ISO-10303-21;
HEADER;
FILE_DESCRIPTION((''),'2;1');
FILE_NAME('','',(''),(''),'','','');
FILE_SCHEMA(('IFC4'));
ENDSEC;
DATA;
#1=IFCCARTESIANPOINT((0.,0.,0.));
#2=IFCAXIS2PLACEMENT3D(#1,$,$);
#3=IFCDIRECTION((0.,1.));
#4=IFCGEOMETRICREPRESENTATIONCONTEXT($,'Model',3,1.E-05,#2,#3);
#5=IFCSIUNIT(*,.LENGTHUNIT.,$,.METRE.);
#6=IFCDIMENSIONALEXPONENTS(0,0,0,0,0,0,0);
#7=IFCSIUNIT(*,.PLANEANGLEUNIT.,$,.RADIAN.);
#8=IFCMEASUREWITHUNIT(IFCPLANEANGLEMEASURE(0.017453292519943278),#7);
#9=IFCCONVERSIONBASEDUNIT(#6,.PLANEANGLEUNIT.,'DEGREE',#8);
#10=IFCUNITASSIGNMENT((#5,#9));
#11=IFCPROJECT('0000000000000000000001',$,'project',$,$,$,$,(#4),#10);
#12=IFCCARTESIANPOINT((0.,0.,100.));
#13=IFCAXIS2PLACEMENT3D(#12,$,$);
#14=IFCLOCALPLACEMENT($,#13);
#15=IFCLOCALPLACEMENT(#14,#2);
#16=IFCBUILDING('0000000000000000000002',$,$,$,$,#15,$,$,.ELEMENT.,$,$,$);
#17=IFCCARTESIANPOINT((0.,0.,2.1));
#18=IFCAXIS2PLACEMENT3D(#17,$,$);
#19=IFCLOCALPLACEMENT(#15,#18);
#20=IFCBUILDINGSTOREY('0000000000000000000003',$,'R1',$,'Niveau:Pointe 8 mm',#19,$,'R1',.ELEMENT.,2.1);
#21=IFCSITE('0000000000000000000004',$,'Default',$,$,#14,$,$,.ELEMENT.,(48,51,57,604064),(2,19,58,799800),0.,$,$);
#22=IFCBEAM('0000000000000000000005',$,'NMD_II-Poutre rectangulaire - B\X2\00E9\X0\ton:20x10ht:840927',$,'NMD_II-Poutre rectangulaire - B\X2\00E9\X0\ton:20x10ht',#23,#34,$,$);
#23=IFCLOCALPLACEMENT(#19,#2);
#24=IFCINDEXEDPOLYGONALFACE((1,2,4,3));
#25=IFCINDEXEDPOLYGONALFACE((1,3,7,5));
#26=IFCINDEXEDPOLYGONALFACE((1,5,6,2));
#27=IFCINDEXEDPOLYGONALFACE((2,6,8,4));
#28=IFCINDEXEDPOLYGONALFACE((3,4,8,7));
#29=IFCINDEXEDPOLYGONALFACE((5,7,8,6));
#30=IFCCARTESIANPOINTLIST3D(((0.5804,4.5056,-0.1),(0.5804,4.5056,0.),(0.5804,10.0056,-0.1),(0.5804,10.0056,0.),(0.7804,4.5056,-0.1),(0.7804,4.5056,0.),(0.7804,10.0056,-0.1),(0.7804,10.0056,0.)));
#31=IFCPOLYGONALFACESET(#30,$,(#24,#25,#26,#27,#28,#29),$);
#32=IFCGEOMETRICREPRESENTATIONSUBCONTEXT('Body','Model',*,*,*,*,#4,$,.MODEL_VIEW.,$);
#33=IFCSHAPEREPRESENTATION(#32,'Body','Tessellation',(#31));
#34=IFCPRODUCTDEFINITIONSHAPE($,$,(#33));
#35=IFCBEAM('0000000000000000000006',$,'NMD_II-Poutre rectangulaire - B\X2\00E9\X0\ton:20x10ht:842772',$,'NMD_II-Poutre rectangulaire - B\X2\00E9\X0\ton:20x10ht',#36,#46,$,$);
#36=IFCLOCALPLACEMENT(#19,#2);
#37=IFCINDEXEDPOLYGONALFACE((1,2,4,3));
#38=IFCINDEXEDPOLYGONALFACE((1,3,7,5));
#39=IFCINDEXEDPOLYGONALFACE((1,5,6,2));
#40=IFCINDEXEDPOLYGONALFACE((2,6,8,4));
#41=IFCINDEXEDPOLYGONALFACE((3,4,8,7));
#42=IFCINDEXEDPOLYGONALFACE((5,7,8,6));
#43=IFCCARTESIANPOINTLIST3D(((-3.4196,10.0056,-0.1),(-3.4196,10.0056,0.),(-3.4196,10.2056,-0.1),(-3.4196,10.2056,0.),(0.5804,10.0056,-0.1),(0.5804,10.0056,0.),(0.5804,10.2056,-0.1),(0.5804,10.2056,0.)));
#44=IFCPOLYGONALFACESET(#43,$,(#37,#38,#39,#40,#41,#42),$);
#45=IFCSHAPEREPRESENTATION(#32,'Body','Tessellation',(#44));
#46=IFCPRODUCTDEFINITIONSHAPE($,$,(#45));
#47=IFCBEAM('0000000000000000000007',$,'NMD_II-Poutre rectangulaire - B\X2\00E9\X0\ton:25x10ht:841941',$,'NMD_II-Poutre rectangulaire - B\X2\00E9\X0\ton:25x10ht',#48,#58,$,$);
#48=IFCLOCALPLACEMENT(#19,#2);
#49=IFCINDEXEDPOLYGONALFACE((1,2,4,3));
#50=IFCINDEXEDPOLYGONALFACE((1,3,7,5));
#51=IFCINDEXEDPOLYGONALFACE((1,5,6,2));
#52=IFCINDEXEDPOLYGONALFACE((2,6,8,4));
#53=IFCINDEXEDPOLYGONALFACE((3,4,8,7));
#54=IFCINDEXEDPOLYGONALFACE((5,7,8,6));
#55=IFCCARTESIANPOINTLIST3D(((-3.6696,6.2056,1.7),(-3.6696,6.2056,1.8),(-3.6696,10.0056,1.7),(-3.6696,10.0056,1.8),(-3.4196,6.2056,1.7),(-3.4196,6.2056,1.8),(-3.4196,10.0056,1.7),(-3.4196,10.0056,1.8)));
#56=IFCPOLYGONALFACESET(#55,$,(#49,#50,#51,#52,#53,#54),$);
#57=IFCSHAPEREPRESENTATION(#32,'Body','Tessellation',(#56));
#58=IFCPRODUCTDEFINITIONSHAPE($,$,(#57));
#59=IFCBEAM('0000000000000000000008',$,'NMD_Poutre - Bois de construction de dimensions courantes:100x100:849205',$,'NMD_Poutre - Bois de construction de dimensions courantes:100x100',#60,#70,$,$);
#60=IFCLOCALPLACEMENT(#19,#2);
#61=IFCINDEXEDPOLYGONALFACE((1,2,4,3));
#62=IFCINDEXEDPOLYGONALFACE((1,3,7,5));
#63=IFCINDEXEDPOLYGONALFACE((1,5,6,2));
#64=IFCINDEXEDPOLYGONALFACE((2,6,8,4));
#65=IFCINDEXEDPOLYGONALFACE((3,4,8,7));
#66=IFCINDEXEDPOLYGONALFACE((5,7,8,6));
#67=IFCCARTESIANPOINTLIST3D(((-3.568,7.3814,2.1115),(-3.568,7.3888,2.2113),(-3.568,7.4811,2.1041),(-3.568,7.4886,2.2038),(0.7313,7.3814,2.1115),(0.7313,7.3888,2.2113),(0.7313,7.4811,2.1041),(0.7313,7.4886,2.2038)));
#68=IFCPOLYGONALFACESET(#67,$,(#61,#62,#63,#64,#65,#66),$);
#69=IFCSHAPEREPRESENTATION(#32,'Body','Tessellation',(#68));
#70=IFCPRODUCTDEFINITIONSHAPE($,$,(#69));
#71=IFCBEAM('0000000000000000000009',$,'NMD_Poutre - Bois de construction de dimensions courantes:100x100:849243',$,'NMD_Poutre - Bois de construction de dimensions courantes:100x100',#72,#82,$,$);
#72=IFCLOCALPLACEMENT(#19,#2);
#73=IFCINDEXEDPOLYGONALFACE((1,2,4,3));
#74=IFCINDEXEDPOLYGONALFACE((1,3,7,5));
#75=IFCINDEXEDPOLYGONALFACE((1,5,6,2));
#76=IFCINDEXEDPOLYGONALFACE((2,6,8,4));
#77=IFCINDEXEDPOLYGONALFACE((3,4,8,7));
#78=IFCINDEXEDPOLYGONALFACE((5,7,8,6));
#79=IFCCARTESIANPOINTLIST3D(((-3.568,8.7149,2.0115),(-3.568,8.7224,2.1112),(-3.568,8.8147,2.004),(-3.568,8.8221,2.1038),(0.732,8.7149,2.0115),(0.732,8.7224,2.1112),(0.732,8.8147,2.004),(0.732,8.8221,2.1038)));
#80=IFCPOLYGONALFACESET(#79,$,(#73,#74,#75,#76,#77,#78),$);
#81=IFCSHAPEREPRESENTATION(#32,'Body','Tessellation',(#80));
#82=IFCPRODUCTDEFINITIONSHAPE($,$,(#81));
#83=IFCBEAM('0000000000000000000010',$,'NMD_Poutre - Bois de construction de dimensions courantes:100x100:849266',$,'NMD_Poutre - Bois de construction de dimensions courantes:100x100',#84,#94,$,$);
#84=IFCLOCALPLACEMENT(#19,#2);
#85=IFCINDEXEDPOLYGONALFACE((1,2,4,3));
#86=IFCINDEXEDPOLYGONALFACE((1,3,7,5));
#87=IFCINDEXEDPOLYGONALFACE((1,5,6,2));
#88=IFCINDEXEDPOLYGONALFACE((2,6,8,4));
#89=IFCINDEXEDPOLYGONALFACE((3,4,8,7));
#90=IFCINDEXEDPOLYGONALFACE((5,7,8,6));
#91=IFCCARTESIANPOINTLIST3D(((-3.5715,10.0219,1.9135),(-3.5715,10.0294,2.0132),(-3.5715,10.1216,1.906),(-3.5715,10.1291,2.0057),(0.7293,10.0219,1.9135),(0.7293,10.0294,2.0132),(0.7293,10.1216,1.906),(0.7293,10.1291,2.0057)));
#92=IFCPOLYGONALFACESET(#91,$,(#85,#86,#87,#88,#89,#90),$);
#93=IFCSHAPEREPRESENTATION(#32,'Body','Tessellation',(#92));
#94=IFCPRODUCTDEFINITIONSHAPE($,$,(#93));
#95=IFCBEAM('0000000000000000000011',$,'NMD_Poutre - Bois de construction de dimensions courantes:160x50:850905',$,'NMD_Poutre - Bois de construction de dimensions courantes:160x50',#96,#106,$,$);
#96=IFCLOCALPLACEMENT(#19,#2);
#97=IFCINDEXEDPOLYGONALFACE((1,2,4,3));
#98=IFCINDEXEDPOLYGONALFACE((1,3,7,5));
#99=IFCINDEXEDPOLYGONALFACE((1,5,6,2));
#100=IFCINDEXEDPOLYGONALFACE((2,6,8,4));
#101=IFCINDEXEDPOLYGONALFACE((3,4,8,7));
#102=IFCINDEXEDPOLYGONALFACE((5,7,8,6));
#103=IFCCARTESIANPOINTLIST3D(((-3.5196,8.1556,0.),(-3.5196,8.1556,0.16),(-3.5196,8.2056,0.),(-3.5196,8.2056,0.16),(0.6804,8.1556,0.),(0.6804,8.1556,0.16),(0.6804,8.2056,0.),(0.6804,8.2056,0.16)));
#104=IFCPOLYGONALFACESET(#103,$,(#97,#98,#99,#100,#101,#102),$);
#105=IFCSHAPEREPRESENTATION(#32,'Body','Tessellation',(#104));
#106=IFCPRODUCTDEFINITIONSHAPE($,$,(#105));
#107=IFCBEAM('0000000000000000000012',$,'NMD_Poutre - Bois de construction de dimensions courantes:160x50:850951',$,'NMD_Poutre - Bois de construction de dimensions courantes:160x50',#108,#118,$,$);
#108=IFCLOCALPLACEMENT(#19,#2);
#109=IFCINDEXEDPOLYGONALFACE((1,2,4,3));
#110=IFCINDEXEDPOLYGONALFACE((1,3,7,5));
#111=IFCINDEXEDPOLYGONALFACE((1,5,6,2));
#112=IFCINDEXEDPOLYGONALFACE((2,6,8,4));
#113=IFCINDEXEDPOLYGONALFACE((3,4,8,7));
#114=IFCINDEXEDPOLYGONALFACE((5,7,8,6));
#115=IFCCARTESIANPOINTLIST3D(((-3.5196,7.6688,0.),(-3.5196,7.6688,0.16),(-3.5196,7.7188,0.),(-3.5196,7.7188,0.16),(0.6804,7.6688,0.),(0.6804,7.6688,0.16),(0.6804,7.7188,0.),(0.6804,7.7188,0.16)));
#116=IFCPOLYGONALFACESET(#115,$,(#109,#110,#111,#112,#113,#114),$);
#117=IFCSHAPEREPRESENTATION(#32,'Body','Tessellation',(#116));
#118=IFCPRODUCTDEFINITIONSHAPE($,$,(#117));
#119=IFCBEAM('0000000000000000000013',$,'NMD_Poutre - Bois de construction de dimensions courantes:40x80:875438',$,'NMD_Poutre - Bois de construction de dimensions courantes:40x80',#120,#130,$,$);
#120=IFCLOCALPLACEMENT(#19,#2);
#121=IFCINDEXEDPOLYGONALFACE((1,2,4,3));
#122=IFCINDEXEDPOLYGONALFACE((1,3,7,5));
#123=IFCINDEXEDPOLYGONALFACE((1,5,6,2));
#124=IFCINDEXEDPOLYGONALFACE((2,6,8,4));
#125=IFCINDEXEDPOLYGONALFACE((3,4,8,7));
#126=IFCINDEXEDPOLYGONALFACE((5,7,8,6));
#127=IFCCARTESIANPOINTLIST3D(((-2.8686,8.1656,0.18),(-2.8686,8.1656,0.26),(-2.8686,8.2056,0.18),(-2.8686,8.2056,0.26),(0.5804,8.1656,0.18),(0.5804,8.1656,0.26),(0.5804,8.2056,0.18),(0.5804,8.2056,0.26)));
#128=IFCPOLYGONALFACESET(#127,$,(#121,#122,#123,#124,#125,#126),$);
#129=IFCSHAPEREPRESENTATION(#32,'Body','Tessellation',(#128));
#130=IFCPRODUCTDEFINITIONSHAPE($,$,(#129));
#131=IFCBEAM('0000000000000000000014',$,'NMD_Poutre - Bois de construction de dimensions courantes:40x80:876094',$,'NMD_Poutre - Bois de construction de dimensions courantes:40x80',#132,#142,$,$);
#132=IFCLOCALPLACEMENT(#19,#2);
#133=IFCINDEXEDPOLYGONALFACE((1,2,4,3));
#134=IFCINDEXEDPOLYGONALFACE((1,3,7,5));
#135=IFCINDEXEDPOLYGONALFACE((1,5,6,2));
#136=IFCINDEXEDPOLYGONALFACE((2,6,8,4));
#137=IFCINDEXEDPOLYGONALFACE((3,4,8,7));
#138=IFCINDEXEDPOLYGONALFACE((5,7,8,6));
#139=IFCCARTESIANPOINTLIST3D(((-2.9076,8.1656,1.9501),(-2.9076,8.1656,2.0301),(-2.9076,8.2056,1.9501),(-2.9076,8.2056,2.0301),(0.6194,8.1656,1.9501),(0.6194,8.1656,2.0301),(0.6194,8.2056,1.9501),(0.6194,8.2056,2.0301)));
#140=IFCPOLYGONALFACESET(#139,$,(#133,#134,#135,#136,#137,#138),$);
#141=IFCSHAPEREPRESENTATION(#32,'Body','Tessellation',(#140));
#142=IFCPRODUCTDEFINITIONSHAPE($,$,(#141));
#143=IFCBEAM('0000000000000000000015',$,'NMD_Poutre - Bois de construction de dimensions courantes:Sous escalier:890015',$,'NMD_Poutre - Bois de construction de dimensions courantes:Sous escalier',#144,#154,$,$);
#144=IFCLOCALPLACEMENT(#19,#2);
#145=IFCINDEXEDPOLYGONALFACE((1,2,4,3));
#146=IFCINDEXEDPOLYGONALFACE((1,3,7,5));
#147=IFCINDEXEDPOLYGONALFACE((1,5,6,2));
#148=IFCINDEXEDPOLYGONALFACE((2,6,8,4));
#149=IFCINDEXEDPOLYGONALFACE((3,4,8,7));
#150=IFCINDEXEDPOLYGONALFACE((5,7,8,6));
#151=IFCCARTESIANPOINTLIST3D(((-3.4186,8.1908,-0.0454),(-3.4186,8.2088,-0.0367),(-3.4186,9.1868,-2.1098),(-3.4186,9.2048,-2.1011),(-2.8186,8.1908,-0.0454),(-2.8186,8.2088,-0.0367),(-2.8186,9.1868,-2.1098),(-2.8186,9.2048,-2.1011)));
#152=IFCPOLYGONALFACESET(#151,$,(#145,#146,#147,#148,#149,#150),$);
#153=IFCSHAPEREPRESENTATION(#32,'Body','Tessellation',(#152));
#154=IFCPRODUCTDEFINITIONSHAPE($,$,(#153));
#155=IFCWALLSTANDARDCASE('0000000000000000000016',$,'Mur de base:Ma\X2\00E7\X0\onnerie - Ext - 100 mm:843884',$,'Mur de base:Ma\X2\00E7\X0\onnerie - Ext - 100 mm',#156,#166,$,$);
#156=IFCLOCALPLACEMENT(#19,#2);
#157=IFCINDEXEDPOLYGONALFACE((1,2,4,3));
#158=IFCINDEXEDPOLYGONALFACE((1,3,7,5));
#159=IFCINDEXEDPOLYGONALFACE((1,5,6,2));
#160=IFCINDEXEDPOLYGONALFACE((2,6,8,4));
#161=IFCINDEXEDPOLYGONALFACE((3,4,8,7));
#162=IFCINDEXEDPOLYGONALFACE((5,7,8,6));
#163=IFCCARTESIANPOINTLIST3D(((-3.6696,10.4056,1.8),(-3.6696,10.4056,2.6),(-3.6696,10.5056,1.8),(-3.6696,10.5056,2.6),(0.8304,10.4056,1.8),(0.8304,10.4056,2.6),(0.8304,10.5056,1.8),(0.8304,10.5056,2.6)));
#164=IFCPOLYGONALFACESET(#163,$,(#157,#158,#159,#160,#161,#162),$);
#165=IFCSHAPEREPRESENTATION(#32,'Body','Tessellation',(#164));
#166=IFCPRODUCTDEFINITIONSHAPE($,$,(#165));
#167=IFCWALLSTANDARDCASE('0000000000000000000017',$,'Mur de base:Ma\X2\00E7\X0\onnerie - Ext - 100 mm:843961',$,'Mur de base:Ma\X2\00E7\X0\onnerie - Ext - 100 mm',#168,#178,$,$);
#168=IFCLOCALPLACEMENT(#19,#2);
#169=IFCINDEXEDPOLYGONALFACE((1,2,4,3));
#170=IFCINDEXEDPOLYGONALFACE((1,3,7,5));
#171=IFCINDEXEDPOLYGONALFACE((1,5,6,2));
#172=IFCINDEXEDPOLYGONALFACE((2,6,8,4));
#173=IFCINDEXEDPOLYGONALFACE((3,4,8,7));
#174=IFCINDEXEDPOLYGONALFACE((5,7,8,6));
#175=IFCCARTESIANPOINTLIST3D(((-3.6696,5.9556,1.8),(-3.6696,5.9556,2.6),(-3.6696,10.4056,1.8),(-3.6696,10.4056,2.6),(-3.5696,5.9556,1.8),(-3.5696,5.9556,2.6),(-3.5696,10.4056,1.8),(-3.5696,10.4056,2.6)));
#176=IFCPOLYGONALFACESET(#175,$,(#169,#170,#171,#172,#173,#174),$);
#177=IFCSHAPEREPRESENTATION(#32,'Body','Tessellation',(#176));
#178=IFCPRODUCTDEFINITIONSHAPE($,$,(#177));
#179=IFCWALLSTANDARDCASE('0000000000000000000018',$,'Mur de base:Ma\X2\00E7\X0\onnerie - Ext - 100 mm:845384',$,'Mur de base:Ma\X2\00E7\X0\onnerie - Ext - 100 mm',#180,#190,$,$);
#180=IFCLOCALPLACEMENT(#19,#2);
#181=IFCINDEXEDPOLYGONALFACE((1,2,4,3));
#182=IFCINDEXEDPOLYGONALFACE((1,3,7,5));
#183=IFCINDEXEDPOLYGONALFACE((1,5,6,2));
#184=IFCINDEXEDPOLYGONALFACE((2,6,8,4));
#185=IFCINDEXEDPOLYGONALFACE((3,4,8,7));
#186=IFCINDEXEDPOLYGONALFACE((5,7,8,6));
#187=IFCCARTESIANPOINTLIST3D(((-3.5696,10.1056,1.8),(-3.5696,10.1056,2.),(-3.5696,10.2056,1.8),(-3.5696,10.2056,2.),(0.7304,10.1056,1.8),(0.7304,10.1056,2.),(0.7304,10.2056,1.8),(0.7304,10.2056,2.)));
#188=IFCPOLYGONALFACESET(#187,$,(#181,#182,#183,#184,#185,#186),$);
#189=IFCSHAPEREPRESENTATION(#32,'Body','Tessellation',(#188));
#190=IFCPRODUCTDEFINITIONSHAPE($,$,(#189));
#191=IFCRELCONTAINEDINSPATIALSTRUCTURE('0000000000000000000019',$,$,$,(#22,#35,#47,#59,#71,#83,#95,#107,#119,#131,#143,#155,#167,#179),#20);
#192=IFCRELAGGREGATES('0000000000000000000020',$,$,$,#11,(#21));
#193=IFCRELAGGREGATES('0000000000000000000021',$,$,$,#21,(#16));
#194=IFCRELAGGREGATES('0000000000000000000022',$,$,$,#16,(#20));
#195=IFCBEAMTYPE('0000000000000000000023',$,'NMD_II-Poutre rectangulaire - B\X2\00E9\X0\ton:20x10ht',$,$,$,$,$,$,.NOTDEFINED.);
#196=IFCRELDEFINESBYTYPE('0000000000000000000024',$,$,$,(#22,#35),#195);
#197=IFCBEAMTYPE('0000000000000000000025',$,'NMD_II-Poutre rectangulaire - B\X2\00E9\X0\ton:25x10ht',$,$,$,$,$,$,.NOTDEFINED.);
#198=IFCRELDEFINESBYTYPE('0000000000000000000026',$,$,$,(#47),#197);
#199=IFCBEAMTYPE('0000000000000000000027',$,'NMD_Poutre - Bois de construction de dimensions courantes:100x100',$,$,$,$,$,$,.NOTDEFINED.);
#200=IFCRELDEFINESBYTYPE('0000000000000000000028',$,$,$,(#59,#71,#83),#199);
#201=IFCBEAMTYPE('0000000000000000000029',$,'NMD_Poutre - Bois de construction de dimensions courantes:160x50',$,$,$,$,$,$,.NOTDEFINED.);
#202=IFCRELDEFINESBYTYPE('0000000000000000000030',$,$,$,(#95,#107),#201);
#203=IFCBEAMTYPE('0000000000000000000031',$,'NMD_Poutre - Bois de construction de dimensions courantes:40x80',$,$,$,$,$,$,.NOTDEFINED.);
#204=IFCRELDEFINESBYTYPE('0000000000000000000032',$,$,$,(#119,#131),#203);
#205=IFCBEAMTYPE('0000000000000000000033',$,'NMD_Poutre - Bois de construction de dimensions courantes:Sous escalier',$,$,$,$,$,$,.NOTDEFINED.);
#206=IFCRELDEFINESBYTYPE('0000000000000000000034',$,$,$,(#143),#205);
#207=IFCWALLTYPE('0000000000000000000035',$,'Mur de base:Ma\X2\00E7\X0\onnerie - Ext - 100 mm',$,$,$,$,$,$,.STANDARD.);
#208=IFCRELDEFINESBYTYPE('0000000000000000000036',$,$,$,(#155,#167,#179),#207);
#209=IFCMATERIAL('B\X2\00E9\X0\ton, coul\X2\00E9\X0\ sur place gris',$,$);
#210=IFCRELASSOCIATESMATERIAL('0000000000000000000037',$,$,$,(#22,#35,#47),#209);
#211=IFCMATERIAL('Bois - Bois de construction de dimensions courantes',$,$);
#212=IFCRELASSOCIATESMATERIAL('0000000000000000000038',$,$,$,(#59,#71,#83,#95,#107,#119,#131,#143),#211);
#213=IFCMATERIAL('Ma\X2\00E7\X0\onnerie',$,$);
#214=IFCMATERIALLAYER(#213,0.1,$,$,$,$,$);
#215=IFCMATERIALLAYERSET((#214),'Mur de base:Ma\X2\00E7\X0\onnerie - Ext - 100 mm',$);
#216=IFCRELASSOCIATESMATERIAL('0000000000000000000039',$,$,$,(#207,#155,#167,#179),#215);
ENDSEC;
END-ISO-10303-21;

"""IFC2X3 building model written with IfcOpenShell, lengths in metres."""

from ifc_helpers import new_model, entity, si_unit, converted_unit, direction, frame, frame_2d, origin, origin_2d_with_axis, place, context, subcontext, project, spatial, rectangle, extrude, material, layer, layer_set, layer_usage, type_object, element, save


model = new_model("IFC2X3")

# Units and contexts
model_context = context("Model", 3, precision=1e-05, world=origin(), true_north=direction((0.0, 1.0)))
body_context = subcontext(model_context, "Body", "Model", "MODEL_VIEW")
ifc_project = project(units=[si_unit("LENGTHUNIT", "METRE"), converted_unit("PLANEANGLEUNIT", "DEGREE", entity("IfcPlaneAngleMeasure", 0.017453292519943278), si_unit("PLANEANGLEUNIT", "RADIAN"), dimensions=[0, 0, 0, 0, 0, 0, 0])], contexts=[model_context])

# Site, building, storey
site_placement = place(None, frame((0.0, 0.0, 100.0)))
site = spatial("IfcSite", under=ifc_project, at=site_placement, Name="Default", CompositionType="ELEMENT", RefLatitude=(48, 51, 57, 604064), RefLongitude=(2, 19, 58, 799800), RefElevation=0.0)
building_placement = place(site_placement, origin())
building = spatial("IfcBuilding", under=site, at=building_placement, CompositionType="ELEMENT")
storey_placement = place(building_placement, frame((0.0, 0.0, 2.1)))
storey = spatial("IfcBuildingStorey", under=building, at=storey_placement, Name="R1", ObjectType="Niveau:Pointe 8 mm", LongName="R1", CompositionType="ELEMENT", Elevation=2.1)

# Beams
ifc_material_1 = material(Name="Béton, coulé sur place gris")
beam_type_1 = type_object("IfcBeamType", Name="NMD_II-Poutre rectangulaire - Béton:20x10ht", PredefinedType="NOTDEFINED")
beam_1_placement = place(storey_placement, frame((0.6804, 10.0056, 0.0), z_axis=(0.0, 0.0, 1.0), x_axis=(0.0, -1.0, 0.0)))
element("IfcBeam", 1, at=beam_1_placement, inside=storey, type_object=beam_type_1, material=ifc_material_1, Name="NMD_II-Poutre rectangulaire - Béton:20x10ht:840927", ObjectType="NMD_II-Poutre rectangulaire - Béton:20x10ht", context=body_context, shape_type="SweptSolid", body=[
    extrude(rectangle(XDim=0.1, YDim=0.2, at=frame_2d((0.0, 0.0), x_axis=(1.0, 0.0))), frame((0.0, 0.0, -0.05), z_axis=(1.0, 0.0, 0.0), x_axis=(0.0, 0.0, -1.0)), (0.0, 0.0, 1.0), 5.5),
])
beam_2_placement = place(storey_placement, frame((0.5804, 10.1056, 0.0), z_axis=(0.0, 0.0, 1.0), x_axis=(-1.0, 0.0, 0.0)))
element("IfcBeam", 2, at=beam_2_placement, inside=storey, type_object=beam_type_1, material=ifc_material_1, Name="NMD_II-Poutre rectangulaire - Béton:20x10ht:842772", ObjectType="NMD_II-Poutre rectangulaire - Béton:20x10ht", context=body_context, shape_type="SweptSolid", body=[
    extrude(rectangle(XDim=0.1, YDim=0.2, at=frame_2d((0.0, 0.0), x_axis=(1.0, 0.0))), frame((0.0, 0.0, -0.05), z_axis=(1.0, 0.0, 0.0), x_axis=(0.0, 0.0, -1.0)), (0.0, 0.0, 1.0), 4.0),
])
beam_type_2 = type_object("IfcBeamType", Name="NMD_II-Poutre rectangulaire - Béton:25x10ht", PredefinedType="NOTDEFINED")
beam_3_placement = place(storey_placement, frame((-3.5446, 10.0056, 1.8), z_axis=(0.0, 0.0, 1.0), x_axis=(0.0, -1.0, 0.0)))
element("IfcBeam", 3, at=beam_3_placement, inside=storey, type_object=beam_type_2, material=ifc_material_1, Name="NMD_II-Poutre rectangulaire - Béton:25x10ht:841941", ObjectType="NMD_II-Poutre rectangulaire - Béton:25x10ht", context=body_context, shape_type="SweptSolid", body=[
    extrude(rectangle(XDim=0.1, YDim=0.25, at=frame_2d((0.0, 0.0), x_axis=(1.0, 0.0))), frame((0.0, 0.0, -0.05), z_axis=(1.0, 0.0, 0.0), x_axis=(0.0, 0.0, -1.0)), (0.0, 0.0, 1.0), 3.8),
])
ifc_material_2 = material(Name="Bois - Bois de construction de dimensions courantes")
beam_type_3 = type_object("IfcBeamType", Name="NMD_Poutre - Bois de construction de dimensions courantes:100x100", PredefinedType="NOTDEFINED")
beam_4_placement = place(storey_placement, frame((-3.5685, 7.4387, 2.2075)))
element("IfcBeam", 4, at=beam_4_placement, inside=storey, type_object=beam_type_3, material=ifc_material_2, Name="NMD_Poutre - Bois de construction de dimensions courantes:100x100:849205", ObjectType="NMD_Poutre - Bois de construction de dimensions courantes:100x100", context=body_context, shape_type="SweptSolid", body=[
    extrude(rectangle(XDim=0.1, YDim=0.1, at=frame_2d((0.0, 0.0), x_axis=(0.0, 1.0))), frame((0.0004, -0.0037, -0.0499), z_axis=(1.0, 0.0, 0.0), x_axis=(0.0, -0.997198, 0.074805)), (0.0, 0.0, 1.0), 4.2993),
])
beam_5_placement = place(storey_placement, frame((-3.5685, 8.7723, 2.1075)))
element("IfcBeam", 5, at=beam_5_placement, inside=storey, type_object=beam_type_3, material=ifc_material_2, Name="NMD_Poutre - Bois de construction de dimensions courantes:100x100:849243", ObjectType="NMD_Poutre - Bois de construction de dimensions courantes:100x100", context=body_context, shape_type="SweptSolid", body=[
    extrude(rectangle(XDim=0.1, YDim=0.1, at=frame_2d((0.0, 0.0), x_axis=(0.0, 1.0))), frame((0.0004, -0.0037, -0.0499), z_axis=(1.0, 0.0, 0.0), x_axis=(0.0, -0.997198, 0.074805)), (0.0, 0.0, 1.0), 4.3001),
])
beam_6_placement = place(storey_placement, frame((-3.5685, 10.0792, 2.0095)))
element("IfcBeam", 6, at=beam_6_placement, inside=storey, type_object=beam_type_3, material=ifc_material_2, Name="NMD_Poutre - Bois de construction de dimensions courantes:100x100:849266", ObjectType="NMD_Poutre - Bois de construction de dimensions courantes:100x100", context=body_context, shape_type="SweptSolid", body=[
    extrude(rectangle(XDim=0.1, YDim=0.1, at=frame_2d((0.0, 0.0), x_axis=(0.0, 1.0))), frame((-0.0031, -0.0037, -0.0499), z_axis=(1.0, 0.0, 0.0), x_axis=(0.0, -0.997198, 0.074805)), (0.0, 0.0, 1.0), 4.3008),
])
beam_type_4 = type_object("IfcBeamType", Name="NMD_Poutre - Bois de construction de dimensions courantes:160x50", PredefinedType="NOTDEFINED")
beam_7_placement = place(storey_placement, frame((-3.5196, 8.1806, 0.16)))
element("IfcBeam", 7, at=beam_7_placement, inside=storey, type_object=beam_type_4, material=ifc_material_2, Name="NMD_Poutre - Bois de construction de dimensions courantes:160x50:850905", ObjectType="NMD_Poutre - Bois de construction de dimensions courantes:160x50", context=body_context, shape_type="SweptSolid", body=[
    extrude(rectangle(XDim=0.16, YDim=0.05, at=frame_2d((0.0, 0.0), x_axis=(1.0, 0.0))), frame((0.0, 0.0, -0.08), z_axis=(1.0, 0.0, 0.0), x_axis=(0.0, 0.0, -1.0)), (0.0, 0.0, 1.0), 4.2),
])
beam_8_placement = place(storey_placement, frame((-3.5196, 7.6938, 0.16)))
element("IfcBeam", 8, at=beam_8_placement, inside=storey, type_object=beam_type_4, material=ifc_material_2, Name="NMD_Poutre - Bois de construction de dimensions courantes:160x50:850951", ObjectType="NMD_Poutre - Bois de construction de dimensions courantes:160x50", context=body_context, shape_type="SweptSolid", body=[
    extrude(rectangle(XDim=0.16, YDim=0.05, at=frame_2d((0.0, 0.0), x_axis=(1.0, 0.0))), frame((0.0, 0.0, -0.08), z_axis=(1.0, 0.0, 0.0), x_axis=(0.0, 0.0, -1.0)), (0.0, 0.0, 1.0), 4.2),
])
beam_type_5 = type_object("IfcBeamType", Name="NMD_Poutre - Bois de construction de dimensions courantes:40x80", PredefinedType="NOTDEFINED")
beam_9_placement = place(storey_placement, frame((-2.8686, 8.1856, 0.26)))
element("IfcBeam", 9, at=beam_9_placement, inside=storey, type_object=beam_type_5, material=ifc_material_2, Name="NMD_Poutre - Bois de construction de dimensions courantes:40x80:875438", ObjectType="NMD_Poutre - Bois de construction de dimensions courantes:40x80", context=body_context, shape_type="SweptSolid", body=[
    extrude(rectangle(XDim=0.08, YDim=0.04, at=frame_2d((0.0, 0.0), x_axis=(1.0, 0.0))), frame((0.0, 0.0, -0.04), z_axis=(1.0, 0.0, 0.0), x_axis=(0.0, 0.0, -1.0)), (0.0, 0.0, 1.0), 3.449),
])
beam_10_placement = place(storey_placement, frame((-2.8686, 8.1856, 2.0301)))
element("IfcBeam", 10, at=beam_10_placement, inside=storey, type_object=beam_type_5, material=ifc_material_2, Name="NMD_Poutre - Bois de construction de dimensions courantes:40x80:876094", ObjectType="NMD_Poutre - Bois de construction de dimensions courantes:40x80", context=body_context, shape_type="SweptSolid", body=[
    extrude(rectangle(XDim=0.08, YDim=0.04, at=origin_2d_with_axis()), frame((-0.039, 0.0, -0.04), z_axis=(1.0, 0.0, 0.0), x_axis=(0.0, 0.0, -1.0)), (0.0, 0.0, 1.0), 3.527),
])
beam_type_6 = type_object("IfcBeamType", Name="NMD_Poutre - Bois de construction de dimensions courantes:Sous escalier", PredefinedType="NOTDEFINED")
beam_11_placement = place(storey_placement, frame((-3.1186, 9.2048, -2.1011), z_axis=(1.0, 0.0, 0.0), x_axis=(0.0, -0.434528, 0.900658)))
element("IfcBeam", 11, at=beam_11_placement, inside=storey, type_object=beam_type_6, material=ifc_material_2, Name="NMD_Poutre - Bois de construction de dimensions courantes:Sous escalier:890015", ObjectType="NMD_Poutre - Bois de construction de dimensions courantes:Sous escalier", context=body_context, shape_type="SweptSolid", body=[
    extrude(rectangle(XDim=0.02, YDim=0.6, at=frame_2d((0.0, 0.0), x_axis=(0.0, 1.0))), frame((0.0, 0.01, 0.0), z_axis=(1.0, 0.0, 0.0), x_axis=(0.0, 0.0, -1.0)), (0.0, 0.0, 1.0), 2.2921),
])

# Walls
ifc_material_3 = material(Name="Maçonnerie")
ifc_layer_1 = layer(ifc_material_3, 0.1)
ifc_layer_set_1 = layer_set([ifc_layer_1], Name="Mur de base:Maçonnerie - Ext - 100 mm")
ifc_layer_usage_1 = layer_usage(ifc_layer_set_1, "AXIS2", "NEGATIVE", 0.05)
wall_type_1 = type_object("IfcWallType", Name="Mur de base:Maçonnerie - Ext - 100 mm", PredefinedType="STANDARD", material=ifc_layer_set_1)
wall_1_placement = place(storey_placement, frame((-3.6696, 10.4556, 1.8)))
element("IfcWallStandardCase", 12, at=wall_1_placement, inside=storey, type_object=wall_type_1, material=ifc_layer_usage_1, Name="Mur de base:Maçonnerie - Ext - 100 mm:843884", ObjectType="Mur de base:Maçonnerie - Ext - 100 mm", context=body_context, shape_type="SweptSolid", body=[
    extrude(rectangle(XDim=4.5, YDim=0.1, at=frame_2d((2.25, 0.0), x_axis=(-1.0, 0.0))), origin(), (0.0, 0.0, 1.0), 0.8),
])
ifc_layer_usage_2 = layer_usage(ifc_layer_set_1, "AXIS2", "NEGATIVE", 0.05)
wall_2_placement = place(storey_placement, frame((-3.6196, 10.4056, 1.8), z_axis=(0.0, 0.0, 1.0), x_axis=(0.0, -1.0, 0.0)))
element("IfcWallStandardCase", 13, at=wall_2_placement, inside=storey, type_object=wall_type_1, material=ifc_layer_usage_2, Name="Mur de base:Maçonnerie - Ext - 100 mm:843961", ObjectType="Mur de base:Maçonnerie - Ext - 100 mm", context=body_context, shape_type="SweptSolid", body=[
    extrude(rectangle(XDim=4.45, YDim=0.1, at=frame_2d((2.225, 0.0), x_axis=(-1.0, 0.0))), origin(), (0.0, 0.0, 1.0), 0.8),
])
ifc_layer_usage_3 = layer_usage(ifc_layer_set_1, "AXIS2", "NEGATIVE", 0.05)
wall_3_placement = place(storey_placement, frame((-3.5696, 10.1556, 1.8)))
element("IfcWallStandardCase", 14, at=wall_3_placement, inside=storey, type_object=wall_type_1, material=ifc_layer_usage_3, Name="Mur de base:Maçonnerie - Ext - 100 mm:845384", ObjectType="Mur de base:Maçonnerie - Ext - 100 mm", context=body_context, shape_type="SweptSolid", body=[
    extrude(rectangle(XDim=4.3, YDim=0.1, at=frame_2d((2.15, 0.0), x_axis=(-1.0, 0.0))), origin(), (0.0, 0.0, 1.0), 0.2),
])

save(model, "model.ifc")
